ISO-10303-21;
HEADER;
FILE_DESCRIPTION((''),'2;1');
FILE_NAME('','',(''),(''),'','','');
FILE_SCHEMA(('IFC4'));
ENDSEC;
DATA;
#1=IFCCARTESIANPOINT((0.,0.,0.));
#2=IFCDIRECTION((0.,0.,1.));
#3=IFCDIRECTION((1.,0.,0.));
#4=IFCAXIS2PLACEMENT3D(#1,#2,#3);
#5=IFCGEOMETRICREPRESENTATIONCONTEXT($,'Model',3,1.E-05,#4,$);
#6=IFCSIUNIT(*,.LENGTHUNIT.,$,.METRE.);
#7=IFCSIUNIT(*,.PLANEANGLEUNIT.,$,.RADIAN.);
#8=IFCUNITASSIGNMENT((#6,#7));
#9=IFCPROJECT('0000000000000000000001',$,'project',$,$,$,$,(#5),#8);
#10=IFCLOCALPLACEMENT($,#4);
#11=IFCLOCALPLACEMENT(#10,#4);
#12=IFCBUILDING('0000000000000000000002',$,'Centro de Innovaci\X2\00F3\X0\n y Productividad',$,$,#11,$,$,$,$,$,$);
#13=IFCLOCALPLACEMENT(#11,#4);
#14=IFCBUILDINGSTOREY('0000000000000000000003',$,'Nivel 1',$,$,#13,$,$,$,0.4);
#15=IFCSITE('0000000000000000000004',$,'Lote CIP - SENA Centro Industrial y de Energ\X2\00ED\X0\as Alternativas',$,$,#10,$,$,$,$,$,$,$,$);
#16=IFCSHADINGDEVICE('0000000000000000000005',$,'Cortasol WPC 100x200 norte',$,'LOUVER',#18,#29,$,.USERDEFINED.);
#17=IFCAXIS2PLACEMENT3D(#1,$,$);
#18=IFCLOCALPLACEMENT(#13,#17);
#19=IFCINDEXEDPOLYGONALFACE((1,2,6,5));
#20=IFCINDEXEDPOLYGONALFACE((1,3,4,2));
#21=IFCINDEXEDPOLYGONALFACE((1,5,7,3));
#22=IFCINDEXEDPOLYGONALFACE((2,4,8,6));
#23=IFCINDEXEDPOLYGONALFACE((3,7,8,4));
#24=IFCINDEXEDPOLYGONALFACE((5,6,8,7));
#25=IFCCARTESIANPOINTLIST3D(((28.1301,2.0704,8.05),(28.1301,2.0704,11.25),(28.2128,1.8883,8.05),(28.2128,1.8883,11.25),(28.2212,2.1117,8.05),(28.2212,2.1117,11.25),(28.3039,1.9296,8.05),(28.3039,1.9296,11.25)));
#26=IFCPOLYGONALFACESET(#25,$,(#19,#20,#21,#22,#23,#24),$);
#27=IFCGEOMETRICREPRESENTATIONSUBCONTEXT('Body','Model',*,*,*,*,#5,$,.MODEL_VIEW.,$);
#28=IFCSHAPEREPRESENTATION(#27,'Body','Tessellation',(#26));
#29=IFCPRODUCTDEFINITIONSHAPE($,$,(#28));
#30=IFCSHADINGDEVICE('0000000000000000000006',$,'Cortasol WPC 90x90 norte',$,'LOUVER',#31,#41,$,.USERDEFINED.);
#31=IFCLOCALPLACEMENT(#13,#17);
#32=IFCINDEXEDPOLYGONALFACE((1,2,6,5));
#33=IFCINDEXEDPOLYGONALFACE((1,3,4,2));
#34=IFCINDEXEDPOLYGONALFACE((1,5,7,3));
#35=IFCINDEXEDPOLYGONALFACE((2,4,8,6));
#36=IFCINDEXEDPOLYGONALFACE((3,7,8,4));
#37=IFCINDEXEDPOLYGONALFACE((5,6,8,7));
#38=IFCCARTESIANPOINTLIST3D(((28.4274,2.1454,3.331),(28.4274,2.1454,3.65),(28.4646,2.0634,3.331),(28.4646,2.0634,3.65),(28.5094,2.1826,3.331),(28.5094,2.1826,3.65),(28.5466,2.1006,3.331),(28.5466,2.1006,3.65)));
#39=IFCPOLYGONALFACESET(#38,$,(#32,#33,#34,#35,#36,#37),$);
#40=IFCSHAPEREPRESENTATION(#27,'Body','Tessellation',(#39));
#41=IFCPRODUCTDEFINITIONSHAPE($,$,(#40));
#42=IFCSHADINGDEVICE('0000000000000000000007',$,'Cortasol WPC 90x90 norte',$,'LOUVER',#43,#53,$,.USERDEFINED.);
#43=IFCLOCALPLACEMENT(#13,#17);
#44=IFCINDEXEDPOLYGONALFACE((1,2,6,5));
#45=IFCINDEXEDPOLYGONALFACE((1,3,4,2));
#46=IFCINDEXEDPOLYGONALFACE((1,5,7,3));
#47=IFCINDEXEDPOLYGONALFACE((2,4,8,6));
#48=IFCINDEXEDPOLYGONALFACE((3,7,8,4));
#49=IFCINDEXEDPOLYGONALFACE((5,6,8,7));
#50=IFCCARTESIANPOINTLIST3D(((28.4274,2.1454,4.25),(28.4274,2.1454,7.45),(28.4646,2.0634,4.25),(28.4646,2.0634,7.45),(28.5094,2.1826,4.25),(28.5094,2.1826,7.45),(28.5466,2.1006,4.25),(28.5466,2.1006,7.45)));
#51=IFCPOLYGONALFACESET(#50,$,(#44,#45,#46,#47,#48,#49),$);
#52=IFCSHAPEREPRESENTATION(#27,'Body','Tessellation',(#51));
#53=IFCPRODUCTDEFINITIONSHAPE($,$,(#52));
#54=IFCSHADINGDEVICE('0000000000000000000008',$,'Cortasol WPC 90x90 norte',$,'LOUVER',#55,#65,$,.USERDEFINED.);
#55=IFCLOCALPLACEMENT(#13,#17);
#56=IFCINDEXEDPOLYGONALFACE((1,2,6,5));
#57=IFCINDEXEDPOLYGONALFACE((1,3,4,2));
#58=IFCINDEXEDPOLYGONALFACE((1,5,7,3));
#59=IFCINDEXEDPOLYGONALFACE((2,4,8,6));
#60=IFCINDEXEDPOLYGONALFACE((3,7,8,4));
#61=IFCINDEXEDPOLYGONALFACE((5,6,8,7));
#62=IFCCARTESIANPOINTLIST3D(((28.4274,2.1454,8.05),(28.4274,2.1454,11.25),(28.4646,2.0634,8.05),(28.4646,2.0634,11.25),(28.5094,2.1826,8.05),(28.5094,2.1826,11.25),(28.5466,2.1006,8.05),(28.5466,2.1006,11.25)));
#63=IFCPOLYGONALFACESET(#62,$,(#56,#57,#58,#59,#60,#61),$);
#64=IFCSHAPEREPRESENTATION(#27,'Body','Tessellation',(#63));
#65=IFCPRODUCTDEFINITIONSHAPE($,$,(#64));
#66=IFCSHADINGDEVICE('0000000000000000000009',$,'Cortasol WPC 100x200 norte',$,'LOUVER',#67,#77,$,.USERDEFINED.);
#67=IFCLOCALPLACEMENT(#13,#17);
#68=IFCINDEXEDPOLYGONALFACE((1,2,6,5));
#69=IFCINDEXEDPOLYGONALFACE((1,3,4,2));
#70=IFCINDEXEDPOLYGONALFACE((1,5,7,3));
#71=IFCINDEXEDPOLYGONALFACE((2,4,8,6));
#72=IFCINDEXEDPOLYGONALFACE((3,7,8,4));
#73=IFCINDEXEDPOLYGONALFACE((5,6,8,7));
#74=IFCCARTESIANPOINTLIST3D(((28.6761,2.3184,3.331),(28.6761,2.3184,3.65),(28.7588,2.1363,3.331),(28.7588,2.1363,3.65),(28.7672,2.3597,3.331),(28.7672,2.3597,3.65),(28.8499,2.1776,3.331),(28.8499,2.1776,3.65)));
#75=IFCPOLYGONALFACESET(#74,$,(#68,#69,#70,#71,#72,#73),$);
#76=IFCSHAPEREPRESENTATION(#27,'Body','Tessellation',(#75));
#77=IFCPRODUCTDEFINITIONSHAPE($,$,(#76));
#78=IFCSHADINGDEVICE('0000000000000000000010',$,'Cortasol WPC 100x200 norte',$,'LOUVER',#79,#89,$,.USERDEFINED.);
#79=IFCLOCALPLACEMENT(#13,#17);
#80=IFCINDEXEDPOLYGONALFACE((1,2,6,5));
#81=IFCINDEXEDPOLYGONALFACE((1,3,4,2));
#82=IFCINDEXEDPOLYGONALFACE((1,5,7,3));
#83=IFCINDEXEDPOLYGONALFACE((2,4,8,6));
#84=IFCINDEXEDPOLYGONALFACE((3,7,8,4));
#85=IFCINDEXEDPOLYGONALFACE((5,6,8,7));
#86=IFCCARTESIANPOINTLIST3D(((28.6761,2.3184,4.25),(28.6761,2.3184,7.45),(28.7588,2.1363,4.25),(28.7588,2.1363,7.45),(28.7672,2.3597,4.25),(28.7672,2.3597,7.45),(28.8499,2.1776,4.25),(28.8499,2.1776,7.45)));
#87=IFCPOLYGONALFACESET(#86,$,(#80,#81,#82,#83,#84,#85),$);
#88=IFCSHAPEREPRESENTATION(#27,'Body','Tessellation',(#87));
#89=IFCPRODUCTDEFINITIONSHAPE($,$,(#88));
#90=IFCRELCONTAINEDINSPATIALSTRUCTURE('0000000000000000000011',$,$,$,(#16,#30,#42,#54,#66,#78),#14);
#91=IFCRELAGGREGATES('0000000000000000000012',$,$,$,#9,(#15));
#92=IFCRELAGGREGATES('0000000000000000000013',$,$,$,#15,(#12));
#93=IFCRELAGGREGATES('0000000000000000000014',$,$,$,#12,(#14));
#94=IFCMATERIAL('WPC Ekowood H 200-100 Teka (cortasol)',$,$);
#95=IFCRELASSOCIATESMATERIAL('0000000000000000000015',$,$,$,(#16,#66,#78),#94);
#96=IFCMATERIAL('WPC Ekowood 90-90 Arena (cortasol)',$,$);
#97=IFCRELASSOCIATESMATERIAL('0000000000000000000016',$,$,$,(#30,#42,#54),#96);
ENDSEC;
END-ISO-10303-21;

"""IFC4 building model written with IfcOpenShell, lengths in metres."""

from ifc_helpers import new_model, si_unit, frame, origin_with_axes, place, context, subcontext, project, spatial, polyline, outline, extrude, material, element, save


model = new_model("IFC4")

# Units and contexts
model_context = context("Model", 3, precision=1e-05, world=origin_with_axes())
body_context = subcontext(model_context, "Body", "Model", "MODEL_VIEW")
ifc_project = project(units=[si_unit("LENGTHUNIT", "METRE"), si_unit("PLANEANGLEUNIT", "RADIAN")], contexts=[model_context])

# Site, building, storey
site_placement = place(None, origin_with_axes())
site = spatial("IfcSite", under=ifc_project, at=site_placement, Name="Lote CIP - SENA Centro Industrial y de Energías Alternativas")
building_placement = place(site_placement, origin_with_axes())
building = spatial("IfcBuilding", under=site, at=building_placement, Name="Centro de Innovación y Productividad")
storey_placement = place(building_placement, origin_with_axes())
storey = spatial("IfcBuildingStorey", under=building, at=storey_placement, Name="Nivel 1", Elevation=0.4)

# Shading devices
ifc_material_1 = material(Name="WPC Ekowood H 200-100 Teka (cortasol)")
ifc_material_2 = material(Name="WPC Ekowood 90-90 Arena (cortasol)")
shading_device_1_placement = place(storey_placement, origin_with_axes())
element("IfcShadingDevice", 1, at=shading_device_1_placement, inside=storey, material=ifc_material_1, Name="Cortasol WPC 100x200 norte", ObjectType="LOUVER", PredefinedType="USERDEFINED", context=body_context, shape_type="SweptSolid", body=[
    extrude(outline(polyline([(28.2128, 1.8883), (28.1301, 2.0704), (28.2212, 2.1117), (28.3039, 1.9296), (28.2128, 1.8883)])), frame((0.0, 0.0, 8.05)), (0.0, 0.0, 1.0), 3.2),
])
shading_device_2_placement = place(storey_placement, origin_with_axes())
element("IfcShadingDevice", 2, at=shading_device_2_placement, inside=storey, material=ifc_material_2, Name="Cortasol WPC 90x90 norte", ObjectType="LOUVER", PredefinedType="USERDEFINED", context=body_context, shape_type="SweptSolid", body=[
    extrude(outline(polyline([(28.4646, 2.0634), (28.4274, 2.1454), (28.5094, 2.1826), (28.5466, 2.1006), (28.4646, 2.0634)])), frame((0.0, 0.0, 3.331)), (0.0, 0.0, 1.0), 0.319),
])
shading_device_3_placement = place(storey_placement, origin_with_axes())
element("IfcShadingDevice", 3, at=shading_device_3_placement, inside=storey, material=ifc_material_2, Name="Cortasol WPC 90x90 norte", ObjectType="LOUVER", PredefinedType="USERDEFINED", context=body_context, shape_type="SweptSolid", body=[
    extrude(outline(polyline([(28.4646, 2.0634), (28.4274, 2.1454), (28.5094, 2.1826), (28.5466, 2.1006), (28.4646, 2.0634)])), frame((0.0, 0.0, 4.25)), (0.0, 0.0, 1.0), 3.2),
])
shading_device_4_placement = place(storey_placement, origin_with_axes())
element("IfcShadingDevice", 4, at=shading_device_4_placement, inside=storey, material=ifc_material_2, Name="Cortasol WPC 90x90 norte", ObjectType="LOUVER", PredefinedType="USERDEFINED", context=body_context, shape_type="SweptSolid", body=[
    extrude(outline(polyline([(28.4646, 2.0634), (28.4274, 2.1454), (28.5094, 2.1826), (28.5466, 2.1006), (28.4646, 2.0634)])), frame((0.0, 0.0, 8.05)), (0.0, 0.0, 1.0), 3.2),
])
shading_device_5_placement = place(storey_placement, origin_with_axes())
element("IfcShadingDevice", 5, at=shading_device_5_placement, inside=storey, material=ifc_material_1, Name="Cortasol WPC 100x200 norte", ObjectType="LOUVER", PredefinedType="USERDEFINED", context=body_context, shape_type="SweptSolid", body=[
    extrude(outline(polyline([(28.7588, 2.1363), (28.6761, 2.3184), (28.7672, 2.3597), (28.8499, 2.1776), (28.7588, 2.1363)])), frame((0.0, 0.0, 3.331)), (0.0, 0.0, 1.0), 0.319),
])
shading_device_6_placement = place(storey_placement, origin_with_axes())
element("IfcShadingDevice", 6, at=shading_device_6_placement, inside=storey, material=ifc_material_1, Name="Cortasol WPC 100x200 norte", ObjectType="LOUVER", PredefinedType="USERDEFINED", context=body_context, shape_type="SweptSolid", body=[
    extrude(outline(polyline([(28.7588, 2.1363), (28.6761, 2.3184), (28.7672, 2.3597), (28.8499, 2.1776), (28.7588, 2.1363)])), frame((0.0, 0.0, 4.25)), (0.0, 0.0, 1.0), 3.2),
])

save(model, "model.ifc")
